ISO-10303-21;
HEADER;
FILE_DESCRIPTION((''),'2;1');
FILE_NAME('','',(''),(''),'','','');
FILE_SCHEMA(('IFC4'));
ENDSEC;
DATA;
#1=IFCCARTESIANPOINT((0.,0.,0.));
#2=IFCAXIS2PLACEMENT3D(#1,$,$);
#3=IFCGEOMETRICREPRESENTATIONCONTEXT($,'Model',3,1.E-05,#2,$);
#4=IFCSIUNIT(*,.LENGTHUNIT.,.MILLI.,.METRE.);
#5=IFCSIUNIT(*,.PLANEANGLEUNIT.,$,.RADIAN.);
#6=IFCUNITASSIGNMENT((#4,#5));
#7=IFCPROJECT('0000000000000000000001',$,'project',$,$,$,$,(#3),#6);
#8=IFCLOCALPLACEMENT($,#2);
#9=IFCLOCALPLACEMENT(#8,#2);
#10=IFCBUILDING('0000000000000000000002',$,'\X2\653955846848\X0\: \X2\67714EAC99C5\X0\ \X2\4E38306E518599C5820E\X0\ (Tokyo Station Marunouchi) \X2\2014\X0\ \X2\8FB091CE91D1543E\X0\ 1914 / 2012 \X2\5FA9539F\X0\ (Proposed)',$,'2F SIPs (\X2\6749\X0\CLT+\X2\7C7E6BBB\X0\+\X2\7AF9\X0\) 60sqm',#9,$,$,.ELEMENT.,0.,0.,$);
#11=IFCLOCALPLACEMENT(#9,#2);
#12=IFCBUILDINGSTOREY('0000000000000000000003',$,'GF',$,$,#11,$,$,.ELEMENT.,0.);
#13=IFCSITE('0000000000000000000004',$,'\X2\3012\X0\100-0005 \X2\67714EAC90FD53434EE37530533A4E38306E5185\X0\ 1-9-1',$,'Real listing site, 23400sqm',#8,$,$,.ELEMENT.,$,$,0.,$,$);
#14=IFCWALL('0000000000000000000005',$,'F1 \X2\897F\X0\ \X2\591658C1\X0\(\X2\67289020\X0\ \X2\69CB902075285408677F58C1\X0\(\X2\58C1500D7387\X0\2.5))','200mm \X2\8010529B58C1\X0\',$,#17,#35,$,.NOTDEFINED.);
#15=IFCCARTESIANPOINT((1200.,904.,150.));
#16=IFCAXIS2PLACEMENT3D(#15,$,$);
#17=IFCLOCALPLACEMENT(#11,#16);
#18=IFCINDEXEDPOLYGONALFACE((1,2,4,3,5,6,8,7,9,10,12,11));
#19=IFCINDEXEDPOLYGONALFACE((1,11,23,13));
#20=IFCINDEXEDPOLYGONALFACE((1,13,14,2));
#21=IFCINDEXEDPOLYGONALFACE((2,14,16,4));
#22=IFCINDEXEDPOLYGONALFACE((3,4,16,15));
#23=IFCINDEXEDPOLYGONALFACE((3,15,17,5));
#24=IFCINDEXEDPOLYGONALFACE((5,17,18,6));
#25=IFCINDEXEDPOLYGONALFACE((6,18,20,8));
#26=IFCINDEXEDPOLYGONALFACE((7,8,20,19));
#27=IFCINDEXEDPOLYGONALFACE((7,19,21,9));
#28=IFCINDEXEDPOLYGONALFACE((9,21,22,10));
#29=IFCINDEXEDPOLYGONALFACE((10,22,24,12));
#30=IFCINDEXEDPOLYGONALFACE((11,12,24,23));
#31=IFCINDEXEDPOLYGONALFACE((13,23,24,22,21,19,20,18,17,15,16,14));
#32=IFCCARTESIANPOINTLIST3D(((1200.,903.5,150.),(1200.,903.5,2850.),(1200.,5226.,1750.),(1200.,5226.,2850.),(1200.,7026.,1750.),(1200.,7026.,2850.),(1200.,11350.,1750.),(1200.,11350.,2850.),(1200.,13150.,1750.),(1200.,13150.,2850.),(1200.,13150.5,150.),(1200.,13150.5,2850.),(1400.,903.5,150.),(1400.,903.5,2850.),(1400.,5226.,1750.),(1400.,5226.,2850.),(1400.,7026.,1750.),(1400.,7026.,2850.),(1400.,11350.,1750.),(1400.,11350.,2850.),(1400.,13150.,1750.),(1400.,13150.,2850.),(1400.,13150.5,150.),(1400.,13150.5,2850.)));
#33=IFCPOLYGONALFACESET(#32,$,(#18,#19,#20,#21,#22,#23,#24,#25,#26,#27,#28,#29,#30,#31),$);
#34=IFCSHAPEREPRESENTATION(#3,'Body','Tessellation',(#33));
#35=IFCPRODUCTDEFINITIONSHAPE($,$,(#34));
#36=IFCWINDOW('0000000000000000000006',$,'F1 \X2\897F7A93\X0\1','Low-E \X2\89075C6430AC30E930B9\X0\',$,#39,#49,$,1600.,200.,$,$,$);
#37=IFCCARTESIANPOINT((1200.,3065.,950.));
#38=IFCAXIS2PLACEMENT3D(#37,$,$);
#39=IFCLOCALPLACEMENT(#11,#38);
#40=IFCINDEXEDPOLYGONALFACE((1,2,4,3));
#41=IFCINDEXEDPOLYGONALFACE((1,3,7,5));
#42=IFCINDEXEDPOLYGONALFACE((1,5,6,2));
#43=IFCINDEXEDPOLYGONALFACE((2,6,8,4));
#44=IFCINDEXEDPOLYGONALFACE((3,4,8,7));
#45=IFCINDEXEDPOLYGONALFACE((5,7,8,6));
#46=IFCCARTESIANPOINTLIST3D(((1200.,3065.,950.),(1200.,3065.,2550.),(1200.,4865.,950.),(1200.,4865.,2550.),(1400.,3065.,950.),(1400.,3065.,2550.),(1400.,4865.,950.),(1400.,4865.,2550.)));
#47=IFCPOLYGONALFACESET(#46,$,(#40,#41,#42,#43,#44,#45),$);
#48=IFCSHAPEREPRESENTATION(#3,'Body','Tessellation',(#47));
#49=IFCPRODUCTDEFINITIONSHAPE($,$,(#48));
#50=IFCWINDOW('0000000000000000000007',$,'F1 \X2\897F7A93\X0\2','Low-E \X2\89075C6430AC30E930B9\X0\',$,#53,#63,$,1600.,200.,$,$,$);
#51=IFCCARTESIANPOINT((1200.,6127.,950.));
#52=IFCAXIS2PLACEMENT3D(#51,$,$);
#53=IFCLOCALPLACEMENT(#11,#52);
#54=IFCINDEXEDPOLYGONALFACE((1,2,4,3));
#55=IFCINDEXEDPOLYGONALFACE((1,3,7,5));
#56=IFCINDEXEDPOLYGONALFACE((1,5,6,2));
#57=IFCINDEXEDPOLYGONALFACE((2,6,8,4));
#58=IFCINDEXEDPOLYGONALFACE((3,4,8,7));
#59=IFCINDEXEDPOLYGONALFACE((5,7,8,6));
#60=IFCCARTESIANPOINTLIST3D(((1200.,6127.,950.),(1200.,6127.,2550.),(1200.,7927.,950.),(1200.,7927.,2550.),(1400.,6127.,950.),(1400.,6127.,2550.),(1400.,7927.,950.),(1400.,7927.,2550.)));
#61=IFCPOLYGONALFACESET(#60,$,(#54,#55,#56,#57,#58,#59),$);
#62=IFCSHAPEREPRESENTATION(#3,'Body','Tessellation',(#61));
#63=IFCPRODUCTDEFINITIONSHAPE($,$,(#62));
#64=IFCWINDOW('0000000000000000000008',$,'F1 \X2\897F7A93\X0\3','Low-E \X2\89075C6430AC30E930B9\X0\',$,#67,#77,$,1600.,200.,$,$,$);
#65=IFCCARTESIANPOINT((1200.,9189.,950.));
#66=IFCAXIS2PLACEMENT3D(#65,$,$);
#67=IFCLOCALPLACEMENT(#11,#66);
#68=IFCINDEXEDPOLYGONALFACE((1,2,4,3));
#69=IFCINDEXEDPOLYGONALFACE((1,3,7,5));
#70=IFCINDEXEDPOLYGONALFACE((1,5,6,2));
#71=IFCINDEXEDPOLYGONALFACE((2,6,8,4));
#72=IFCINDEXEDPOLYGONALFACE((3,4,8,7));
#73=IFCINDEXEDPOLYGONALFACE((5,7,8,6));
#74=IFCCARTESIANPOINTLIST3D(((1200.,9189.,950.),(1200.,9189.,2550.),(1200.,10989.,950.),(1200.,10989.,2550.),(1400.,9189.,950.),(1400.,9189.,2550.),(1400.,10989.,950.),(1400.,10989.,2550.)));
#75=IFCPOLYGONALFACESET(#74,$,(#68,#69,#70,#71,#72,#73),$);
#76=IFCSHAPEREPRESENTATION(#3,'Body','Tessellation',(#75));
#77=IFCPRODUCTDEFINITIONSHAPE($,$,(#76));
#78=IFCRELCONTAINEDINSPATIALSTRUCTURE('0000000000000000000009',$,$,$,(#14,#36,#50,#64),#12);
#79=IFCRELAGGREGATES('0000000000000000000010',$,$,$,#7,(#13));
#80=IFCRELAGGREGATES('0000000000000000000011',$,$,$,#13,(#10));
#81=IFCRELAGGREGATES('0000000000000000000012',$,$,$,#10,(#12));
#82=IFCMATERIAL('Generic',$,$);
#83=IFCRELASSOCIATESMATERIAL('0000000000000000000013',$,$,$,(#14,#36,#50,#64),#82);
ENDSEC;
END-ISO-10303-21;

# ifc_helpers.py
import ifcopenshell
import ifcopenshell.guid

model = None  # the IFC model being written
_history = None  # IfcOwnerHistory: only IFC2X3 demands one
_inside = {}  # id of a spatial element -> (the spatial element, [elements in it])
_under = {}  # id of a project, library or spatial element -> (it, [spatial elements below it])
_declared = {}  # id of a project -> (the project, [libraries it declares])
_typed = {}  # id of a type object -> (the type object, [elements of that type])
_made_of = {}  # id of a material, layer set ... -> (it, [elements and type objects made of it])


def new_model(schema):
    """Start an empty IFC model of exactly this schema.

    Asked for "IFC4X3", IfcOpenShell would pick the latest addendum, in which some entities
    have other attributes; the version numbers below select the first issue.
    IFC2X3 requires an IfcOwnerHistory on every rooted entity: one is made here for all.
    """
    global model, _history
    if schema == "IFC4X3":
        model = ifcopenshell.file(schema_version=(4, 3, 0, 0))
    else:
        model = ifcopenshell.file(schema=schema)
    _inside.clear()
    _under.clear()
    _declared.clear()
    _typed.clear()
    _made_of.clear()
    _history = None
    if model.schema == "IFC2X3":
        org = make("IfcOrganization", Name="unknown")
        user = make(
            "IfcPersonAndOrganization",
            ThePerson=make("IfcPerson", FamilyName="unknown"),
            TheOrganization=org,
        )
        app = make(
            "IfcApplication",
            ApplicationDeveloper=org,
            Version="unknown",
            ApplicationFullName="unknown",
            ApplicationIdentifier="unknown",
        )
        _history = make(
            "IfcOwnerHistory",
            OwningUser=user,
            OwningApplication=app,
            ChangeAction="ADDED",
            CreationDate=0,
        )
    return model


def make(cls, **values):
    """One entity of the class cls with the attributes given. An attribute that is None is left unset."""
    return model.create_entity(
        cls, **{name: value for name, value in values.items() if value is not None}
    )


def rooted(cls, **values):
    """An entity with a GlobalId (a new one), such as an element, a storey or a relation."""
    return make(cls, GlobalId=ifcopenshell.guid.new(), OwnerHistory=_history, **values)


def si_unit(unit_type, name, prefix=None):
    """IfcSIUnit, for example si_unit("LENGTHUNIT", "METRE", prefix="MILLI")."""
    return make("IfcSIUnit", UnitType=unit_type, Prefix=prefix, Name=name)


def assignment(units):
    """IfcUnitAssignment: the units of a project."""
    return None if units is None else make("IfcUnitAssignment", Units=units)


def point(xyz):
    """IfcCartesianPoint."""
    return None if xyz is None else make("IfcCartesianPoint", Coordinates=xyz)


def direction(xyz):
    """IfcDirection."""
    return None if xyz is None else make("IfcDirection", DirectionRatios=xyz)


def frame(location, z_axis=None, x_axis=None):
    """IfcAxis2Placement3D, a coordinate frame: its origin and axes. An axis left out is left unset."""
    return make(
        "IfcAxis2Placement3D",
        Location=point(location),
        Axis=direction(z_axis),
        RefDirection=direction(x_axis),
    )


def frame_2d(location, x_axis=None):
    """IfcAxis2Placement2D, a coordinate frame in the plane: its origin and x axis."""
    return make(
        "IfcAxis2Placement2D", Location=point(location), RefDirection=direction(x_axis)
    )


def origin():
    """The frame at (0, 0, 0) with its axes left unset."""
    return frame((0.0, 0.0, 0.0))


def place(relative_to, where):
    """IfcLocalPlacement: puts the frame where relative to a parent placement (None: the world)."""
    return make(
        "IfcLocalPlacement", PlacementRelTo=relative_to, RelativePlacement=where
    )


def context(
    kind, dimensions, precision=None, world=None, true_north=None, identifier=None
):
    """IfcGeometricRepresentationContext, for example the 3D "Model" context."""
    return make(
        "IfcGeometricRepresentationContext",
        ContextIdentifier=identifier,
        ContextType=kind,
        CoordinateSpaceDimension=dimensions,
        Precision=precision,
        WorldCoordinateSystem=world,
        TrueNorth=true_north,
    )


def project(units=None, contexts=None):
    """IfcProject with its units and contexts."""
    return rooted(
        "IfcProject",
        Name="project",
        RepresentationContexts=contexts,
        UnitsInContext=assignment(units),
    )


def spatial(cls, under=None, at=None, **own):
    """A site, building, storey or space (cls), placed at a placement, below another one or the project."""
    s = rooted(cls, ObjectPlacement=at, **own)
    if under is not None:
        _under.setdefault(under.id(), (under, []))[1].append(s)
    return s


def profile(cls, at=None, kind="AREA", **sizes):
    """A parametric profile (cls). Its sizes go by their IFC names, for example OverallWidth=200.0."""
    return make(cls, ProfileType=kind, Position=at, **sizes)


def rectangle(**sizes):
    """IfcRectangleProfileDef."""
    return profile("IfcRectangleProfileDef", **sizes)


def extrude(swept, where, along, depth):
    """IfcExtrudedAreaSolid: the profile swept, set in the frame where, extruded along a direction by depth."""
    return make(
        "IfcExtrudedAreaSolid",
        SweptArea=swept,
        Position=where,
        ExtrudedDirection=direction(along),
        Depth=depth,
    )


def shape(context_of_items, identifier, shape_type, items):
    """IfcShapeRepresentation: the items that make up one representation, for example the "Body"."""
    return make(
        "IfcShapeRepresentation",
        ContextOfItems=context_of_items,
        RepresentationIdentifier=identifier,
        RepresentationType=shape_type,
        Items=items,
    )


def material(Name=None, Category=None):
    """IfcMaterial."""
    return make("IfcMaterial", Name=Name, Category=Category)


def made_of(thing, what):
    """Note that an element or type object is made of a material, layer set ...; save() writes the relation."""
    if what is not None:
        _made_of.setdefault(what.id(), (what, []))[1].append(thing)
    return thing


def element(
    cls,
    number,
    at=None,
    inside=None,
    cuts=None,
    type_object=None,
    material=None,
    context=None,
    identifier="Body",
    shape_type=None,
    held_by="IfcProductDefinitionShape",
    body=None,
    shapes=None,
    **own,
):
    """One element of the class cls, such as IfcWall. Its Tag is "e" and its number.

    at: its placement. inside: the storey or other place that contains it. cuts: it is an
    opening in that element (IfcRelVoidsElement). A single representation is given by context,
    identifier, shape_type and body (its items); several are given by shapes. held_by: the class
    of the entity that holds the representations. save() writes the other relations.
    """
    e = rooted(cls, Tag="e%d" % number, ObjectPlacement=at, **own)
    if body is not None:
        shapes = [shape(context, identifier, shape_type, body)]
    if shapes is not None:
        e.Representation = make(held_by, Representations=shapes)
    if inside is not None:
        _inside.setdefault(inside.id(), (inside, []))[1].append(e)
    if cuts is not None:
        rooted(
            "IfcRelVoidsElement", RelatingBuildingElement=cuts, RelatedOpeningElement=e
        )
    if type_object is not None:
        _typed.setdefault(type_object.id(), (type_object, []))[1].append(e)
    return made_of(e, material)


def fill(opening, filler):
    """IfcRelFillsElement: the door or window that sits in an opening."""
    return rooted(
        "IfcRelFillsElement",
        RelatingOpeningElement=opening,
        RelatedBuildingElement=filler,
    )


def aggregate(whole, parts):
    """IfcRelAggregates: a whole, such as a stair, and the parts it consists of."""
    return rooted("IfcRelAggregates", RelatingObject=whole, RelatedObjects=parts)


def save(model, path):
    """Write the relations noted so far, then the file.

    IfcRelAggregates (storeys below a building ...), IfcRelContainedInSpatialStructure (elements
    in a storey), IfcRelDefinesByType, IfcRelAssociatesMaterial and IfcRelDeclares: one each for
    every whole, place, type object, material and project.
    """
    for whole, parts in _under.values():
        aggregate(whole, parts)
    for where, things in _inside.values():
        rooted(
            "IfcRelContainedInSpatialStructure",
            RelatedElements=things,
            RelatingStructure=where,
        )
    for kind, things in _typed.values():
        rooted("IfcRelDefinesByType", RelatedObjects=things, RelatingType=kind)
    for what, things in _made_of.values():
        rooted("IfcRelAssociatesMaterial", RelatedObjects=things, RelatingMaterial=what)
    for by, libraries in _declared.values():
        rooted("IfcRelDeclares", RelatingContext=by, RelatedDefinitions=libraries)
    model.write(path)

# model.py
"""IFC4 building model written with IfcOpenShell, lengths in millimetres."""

from ifc_helpers import new_model, si_unit, frame, frame_2d, origin, place, context, project, spatial, rectangle, extrude, material, element, fill, save


model = new_model("IFC4")

# Units and contexts
model_context = context("Model", 3, precision=1e-05, world=origin())
ifc_project = project(units=[si_unit("LENGTHUNIT", "METRE", prefix="MILLI"), si_unit("PLANEANGLEUNIT", "RADIAN")], contexts=[model_context])

# Site, building, storey
site_placement = place(None, origin())
site = spatial("IfcSite", under=ifc_project, at=site_placement, Name="〒100-0005 東京都千代田区丸の内 1-9-1", ObjectType="Real listing site, 23400sqm", CompositionType="ELEMENT", RefElevation=0.0)
building_placement = place(site_placement, origin())
building = spatial("IfcBuilding", under=site, at=building_placement, Name="改善案: 東京駅 丸の内駅舎 (Tokyo Station Marunouchi) — 辰野金吾 1914 / 2012 復原 (Proposed)", ObjectType="2F SIPs (杉CLT+籾殻+竹) 60sqm", CompositionType="ELEMENT", ElevationOfRefHeight=0.0, ElevationOfTerrain=0.0)
storey_placement = place(building_placement, origin())
storey = spatial("IfcBuildingStorey", under=building, at=storey_placement, Name="GF", CompositionType="ELEMENT", Elevation=0.0)

# Shared definitions
ifc_material_1 = material(Name="Generic")

# Wall, openings, windows
wall_1_placement = place(storey_placement, frame((1200.0, 904.0, 150.0)))
wall_1 = element("IfcWall", 1, at=wall_1_placement, inside=storey, material=ifc_material_1, Name="F1 西 外壁(木造 構造用合板壁(壁倍率2.5))", Description="200mm 耐力壁", PredefinedType="NOTDEFINED", context=model_context, shape_type="SweptSolid", body=[
    extrude(rectangle(XDim=200.0, YDim=12247.0, at=frame_2d((100.0, 6123.0))), frame((1200.0, 904.0, 150.0)), (0.0, 0.0, 1.0), 2700.0),
])
opening_1_placement = place(storey_placement, frame((1200.0, 3065.0, 950.0)))
opening_1 = element("IfcOpeningElement", 2, at=opening_1_placement, cuts=wall_1, PredefinedType="NOTDEFINED", context=model_context, shape_type="SweptSolid", body=[
    extrude(rectangle(XDim=200.0, YDim=1800.0, at=frame_2d((100.0, 900.0))), frame((1200.0, 3065.0, 950.0)), (0.0, 0.0, 1.0), 1600.0),
])
opening_2_placement = place(storey_placement, frame((1200.0, 6127.0, 950.0)))
opening_2 = element("IfcOpeningElement", 3, at=opening_2_placement, cuts=wall_1, PredefinedType="NOTDEFINED", context=model_context, shape_type="SweptSolid", body=[
    extrude(rectangle(XDim=200.0, YDim=1800.0, at=frame_2d((100.0, 900.0))), frame((1200.0, 6127.0, 950.0)), (0.0, 0.0, 1.0), 1600.0),
])
opening_3_placement = place(storey_placement, frame((1200.0, 9189.0, 950.0)))
opening_3 = element("IfcOpeningElement", 4, at=opening_3_placement, cuts=wall_1, PredefinedType="NOTDEFINED", context=model_context, shape_type="SweptSolid", body=[
    extrude(rectangle(XDim=200.0, YDim=1800.0, at=frame_2d((100.0, 900.0))), frame((1200.0, 9189.0, 950.0)), (0.0, 0.0, 1.0), 1600.0),
])
window_1_placement = place(storey_placement, frame((1200.0, 3065.0, 950.0)))
window_1 = element("IfcWindow", 5, at=window_1_placement, inside=storey, material=ifc_material_1, Name="F1 西窓1", Description="Low-E 複層ガラス", OverallHeight=1600.0, OverallWidth=200.0, context=model_context, shape_type="SweptSolid", body=[
    extrude(rectangle(XDim=200.0, YDim=1800.0, at=frame_2d((100.0, 900.0))), frame((1200.0, 3065.0, 950.0)), (0.0, 0.0, 1.0), 1600.0),
])
fill(opening_1, window_1)
window_2_placement = place(storey_placement, frame((1200.0, 6127.0, 950.0)))
window_2 = element("IfcWindow", 6, at=window_2_placement, inside=storey, material=ifc_material_1, Name="F1 西窓2", Description="Low-E 複層ガラス", OverallHeight=1600.0, OverallWidth=200.0, context=model_context, shape_type="SweptSolid", body=[
    extrude(rectangle(XDim=200.0, YDim=1800.0, at=frame_2d((100.0, 900.0))), frame((1200.0, 6127.0, 950.0)), (0.0, 0.0, 1.0), 1600.0),
])
fill(opening_2, window_2)
window_3_placement = place(storey_placement, frame((1200.0, 9189.0, 950.0)))
window_3 = element("IfcWindow", 7, at=window_3_placement, inside=storey, material=ifc_material_1, Name="F1 西窓3", Description="Low-E 複層ガラス", OverallHeight=1600.0, OverallWidth=200.0, context=model_context, shape_type="SweptSolid", body=[
    extrude(rectangle(XDim=200.0, YDim=1800.0, at=frame_2d((100.0, 900.0))), frame((1200.0, 9189.0, 950.0)), (0.0, 0.0, 1.0), 1600.0),
])
fill(opening_3, window_3)

save(model, "model.ifc")
